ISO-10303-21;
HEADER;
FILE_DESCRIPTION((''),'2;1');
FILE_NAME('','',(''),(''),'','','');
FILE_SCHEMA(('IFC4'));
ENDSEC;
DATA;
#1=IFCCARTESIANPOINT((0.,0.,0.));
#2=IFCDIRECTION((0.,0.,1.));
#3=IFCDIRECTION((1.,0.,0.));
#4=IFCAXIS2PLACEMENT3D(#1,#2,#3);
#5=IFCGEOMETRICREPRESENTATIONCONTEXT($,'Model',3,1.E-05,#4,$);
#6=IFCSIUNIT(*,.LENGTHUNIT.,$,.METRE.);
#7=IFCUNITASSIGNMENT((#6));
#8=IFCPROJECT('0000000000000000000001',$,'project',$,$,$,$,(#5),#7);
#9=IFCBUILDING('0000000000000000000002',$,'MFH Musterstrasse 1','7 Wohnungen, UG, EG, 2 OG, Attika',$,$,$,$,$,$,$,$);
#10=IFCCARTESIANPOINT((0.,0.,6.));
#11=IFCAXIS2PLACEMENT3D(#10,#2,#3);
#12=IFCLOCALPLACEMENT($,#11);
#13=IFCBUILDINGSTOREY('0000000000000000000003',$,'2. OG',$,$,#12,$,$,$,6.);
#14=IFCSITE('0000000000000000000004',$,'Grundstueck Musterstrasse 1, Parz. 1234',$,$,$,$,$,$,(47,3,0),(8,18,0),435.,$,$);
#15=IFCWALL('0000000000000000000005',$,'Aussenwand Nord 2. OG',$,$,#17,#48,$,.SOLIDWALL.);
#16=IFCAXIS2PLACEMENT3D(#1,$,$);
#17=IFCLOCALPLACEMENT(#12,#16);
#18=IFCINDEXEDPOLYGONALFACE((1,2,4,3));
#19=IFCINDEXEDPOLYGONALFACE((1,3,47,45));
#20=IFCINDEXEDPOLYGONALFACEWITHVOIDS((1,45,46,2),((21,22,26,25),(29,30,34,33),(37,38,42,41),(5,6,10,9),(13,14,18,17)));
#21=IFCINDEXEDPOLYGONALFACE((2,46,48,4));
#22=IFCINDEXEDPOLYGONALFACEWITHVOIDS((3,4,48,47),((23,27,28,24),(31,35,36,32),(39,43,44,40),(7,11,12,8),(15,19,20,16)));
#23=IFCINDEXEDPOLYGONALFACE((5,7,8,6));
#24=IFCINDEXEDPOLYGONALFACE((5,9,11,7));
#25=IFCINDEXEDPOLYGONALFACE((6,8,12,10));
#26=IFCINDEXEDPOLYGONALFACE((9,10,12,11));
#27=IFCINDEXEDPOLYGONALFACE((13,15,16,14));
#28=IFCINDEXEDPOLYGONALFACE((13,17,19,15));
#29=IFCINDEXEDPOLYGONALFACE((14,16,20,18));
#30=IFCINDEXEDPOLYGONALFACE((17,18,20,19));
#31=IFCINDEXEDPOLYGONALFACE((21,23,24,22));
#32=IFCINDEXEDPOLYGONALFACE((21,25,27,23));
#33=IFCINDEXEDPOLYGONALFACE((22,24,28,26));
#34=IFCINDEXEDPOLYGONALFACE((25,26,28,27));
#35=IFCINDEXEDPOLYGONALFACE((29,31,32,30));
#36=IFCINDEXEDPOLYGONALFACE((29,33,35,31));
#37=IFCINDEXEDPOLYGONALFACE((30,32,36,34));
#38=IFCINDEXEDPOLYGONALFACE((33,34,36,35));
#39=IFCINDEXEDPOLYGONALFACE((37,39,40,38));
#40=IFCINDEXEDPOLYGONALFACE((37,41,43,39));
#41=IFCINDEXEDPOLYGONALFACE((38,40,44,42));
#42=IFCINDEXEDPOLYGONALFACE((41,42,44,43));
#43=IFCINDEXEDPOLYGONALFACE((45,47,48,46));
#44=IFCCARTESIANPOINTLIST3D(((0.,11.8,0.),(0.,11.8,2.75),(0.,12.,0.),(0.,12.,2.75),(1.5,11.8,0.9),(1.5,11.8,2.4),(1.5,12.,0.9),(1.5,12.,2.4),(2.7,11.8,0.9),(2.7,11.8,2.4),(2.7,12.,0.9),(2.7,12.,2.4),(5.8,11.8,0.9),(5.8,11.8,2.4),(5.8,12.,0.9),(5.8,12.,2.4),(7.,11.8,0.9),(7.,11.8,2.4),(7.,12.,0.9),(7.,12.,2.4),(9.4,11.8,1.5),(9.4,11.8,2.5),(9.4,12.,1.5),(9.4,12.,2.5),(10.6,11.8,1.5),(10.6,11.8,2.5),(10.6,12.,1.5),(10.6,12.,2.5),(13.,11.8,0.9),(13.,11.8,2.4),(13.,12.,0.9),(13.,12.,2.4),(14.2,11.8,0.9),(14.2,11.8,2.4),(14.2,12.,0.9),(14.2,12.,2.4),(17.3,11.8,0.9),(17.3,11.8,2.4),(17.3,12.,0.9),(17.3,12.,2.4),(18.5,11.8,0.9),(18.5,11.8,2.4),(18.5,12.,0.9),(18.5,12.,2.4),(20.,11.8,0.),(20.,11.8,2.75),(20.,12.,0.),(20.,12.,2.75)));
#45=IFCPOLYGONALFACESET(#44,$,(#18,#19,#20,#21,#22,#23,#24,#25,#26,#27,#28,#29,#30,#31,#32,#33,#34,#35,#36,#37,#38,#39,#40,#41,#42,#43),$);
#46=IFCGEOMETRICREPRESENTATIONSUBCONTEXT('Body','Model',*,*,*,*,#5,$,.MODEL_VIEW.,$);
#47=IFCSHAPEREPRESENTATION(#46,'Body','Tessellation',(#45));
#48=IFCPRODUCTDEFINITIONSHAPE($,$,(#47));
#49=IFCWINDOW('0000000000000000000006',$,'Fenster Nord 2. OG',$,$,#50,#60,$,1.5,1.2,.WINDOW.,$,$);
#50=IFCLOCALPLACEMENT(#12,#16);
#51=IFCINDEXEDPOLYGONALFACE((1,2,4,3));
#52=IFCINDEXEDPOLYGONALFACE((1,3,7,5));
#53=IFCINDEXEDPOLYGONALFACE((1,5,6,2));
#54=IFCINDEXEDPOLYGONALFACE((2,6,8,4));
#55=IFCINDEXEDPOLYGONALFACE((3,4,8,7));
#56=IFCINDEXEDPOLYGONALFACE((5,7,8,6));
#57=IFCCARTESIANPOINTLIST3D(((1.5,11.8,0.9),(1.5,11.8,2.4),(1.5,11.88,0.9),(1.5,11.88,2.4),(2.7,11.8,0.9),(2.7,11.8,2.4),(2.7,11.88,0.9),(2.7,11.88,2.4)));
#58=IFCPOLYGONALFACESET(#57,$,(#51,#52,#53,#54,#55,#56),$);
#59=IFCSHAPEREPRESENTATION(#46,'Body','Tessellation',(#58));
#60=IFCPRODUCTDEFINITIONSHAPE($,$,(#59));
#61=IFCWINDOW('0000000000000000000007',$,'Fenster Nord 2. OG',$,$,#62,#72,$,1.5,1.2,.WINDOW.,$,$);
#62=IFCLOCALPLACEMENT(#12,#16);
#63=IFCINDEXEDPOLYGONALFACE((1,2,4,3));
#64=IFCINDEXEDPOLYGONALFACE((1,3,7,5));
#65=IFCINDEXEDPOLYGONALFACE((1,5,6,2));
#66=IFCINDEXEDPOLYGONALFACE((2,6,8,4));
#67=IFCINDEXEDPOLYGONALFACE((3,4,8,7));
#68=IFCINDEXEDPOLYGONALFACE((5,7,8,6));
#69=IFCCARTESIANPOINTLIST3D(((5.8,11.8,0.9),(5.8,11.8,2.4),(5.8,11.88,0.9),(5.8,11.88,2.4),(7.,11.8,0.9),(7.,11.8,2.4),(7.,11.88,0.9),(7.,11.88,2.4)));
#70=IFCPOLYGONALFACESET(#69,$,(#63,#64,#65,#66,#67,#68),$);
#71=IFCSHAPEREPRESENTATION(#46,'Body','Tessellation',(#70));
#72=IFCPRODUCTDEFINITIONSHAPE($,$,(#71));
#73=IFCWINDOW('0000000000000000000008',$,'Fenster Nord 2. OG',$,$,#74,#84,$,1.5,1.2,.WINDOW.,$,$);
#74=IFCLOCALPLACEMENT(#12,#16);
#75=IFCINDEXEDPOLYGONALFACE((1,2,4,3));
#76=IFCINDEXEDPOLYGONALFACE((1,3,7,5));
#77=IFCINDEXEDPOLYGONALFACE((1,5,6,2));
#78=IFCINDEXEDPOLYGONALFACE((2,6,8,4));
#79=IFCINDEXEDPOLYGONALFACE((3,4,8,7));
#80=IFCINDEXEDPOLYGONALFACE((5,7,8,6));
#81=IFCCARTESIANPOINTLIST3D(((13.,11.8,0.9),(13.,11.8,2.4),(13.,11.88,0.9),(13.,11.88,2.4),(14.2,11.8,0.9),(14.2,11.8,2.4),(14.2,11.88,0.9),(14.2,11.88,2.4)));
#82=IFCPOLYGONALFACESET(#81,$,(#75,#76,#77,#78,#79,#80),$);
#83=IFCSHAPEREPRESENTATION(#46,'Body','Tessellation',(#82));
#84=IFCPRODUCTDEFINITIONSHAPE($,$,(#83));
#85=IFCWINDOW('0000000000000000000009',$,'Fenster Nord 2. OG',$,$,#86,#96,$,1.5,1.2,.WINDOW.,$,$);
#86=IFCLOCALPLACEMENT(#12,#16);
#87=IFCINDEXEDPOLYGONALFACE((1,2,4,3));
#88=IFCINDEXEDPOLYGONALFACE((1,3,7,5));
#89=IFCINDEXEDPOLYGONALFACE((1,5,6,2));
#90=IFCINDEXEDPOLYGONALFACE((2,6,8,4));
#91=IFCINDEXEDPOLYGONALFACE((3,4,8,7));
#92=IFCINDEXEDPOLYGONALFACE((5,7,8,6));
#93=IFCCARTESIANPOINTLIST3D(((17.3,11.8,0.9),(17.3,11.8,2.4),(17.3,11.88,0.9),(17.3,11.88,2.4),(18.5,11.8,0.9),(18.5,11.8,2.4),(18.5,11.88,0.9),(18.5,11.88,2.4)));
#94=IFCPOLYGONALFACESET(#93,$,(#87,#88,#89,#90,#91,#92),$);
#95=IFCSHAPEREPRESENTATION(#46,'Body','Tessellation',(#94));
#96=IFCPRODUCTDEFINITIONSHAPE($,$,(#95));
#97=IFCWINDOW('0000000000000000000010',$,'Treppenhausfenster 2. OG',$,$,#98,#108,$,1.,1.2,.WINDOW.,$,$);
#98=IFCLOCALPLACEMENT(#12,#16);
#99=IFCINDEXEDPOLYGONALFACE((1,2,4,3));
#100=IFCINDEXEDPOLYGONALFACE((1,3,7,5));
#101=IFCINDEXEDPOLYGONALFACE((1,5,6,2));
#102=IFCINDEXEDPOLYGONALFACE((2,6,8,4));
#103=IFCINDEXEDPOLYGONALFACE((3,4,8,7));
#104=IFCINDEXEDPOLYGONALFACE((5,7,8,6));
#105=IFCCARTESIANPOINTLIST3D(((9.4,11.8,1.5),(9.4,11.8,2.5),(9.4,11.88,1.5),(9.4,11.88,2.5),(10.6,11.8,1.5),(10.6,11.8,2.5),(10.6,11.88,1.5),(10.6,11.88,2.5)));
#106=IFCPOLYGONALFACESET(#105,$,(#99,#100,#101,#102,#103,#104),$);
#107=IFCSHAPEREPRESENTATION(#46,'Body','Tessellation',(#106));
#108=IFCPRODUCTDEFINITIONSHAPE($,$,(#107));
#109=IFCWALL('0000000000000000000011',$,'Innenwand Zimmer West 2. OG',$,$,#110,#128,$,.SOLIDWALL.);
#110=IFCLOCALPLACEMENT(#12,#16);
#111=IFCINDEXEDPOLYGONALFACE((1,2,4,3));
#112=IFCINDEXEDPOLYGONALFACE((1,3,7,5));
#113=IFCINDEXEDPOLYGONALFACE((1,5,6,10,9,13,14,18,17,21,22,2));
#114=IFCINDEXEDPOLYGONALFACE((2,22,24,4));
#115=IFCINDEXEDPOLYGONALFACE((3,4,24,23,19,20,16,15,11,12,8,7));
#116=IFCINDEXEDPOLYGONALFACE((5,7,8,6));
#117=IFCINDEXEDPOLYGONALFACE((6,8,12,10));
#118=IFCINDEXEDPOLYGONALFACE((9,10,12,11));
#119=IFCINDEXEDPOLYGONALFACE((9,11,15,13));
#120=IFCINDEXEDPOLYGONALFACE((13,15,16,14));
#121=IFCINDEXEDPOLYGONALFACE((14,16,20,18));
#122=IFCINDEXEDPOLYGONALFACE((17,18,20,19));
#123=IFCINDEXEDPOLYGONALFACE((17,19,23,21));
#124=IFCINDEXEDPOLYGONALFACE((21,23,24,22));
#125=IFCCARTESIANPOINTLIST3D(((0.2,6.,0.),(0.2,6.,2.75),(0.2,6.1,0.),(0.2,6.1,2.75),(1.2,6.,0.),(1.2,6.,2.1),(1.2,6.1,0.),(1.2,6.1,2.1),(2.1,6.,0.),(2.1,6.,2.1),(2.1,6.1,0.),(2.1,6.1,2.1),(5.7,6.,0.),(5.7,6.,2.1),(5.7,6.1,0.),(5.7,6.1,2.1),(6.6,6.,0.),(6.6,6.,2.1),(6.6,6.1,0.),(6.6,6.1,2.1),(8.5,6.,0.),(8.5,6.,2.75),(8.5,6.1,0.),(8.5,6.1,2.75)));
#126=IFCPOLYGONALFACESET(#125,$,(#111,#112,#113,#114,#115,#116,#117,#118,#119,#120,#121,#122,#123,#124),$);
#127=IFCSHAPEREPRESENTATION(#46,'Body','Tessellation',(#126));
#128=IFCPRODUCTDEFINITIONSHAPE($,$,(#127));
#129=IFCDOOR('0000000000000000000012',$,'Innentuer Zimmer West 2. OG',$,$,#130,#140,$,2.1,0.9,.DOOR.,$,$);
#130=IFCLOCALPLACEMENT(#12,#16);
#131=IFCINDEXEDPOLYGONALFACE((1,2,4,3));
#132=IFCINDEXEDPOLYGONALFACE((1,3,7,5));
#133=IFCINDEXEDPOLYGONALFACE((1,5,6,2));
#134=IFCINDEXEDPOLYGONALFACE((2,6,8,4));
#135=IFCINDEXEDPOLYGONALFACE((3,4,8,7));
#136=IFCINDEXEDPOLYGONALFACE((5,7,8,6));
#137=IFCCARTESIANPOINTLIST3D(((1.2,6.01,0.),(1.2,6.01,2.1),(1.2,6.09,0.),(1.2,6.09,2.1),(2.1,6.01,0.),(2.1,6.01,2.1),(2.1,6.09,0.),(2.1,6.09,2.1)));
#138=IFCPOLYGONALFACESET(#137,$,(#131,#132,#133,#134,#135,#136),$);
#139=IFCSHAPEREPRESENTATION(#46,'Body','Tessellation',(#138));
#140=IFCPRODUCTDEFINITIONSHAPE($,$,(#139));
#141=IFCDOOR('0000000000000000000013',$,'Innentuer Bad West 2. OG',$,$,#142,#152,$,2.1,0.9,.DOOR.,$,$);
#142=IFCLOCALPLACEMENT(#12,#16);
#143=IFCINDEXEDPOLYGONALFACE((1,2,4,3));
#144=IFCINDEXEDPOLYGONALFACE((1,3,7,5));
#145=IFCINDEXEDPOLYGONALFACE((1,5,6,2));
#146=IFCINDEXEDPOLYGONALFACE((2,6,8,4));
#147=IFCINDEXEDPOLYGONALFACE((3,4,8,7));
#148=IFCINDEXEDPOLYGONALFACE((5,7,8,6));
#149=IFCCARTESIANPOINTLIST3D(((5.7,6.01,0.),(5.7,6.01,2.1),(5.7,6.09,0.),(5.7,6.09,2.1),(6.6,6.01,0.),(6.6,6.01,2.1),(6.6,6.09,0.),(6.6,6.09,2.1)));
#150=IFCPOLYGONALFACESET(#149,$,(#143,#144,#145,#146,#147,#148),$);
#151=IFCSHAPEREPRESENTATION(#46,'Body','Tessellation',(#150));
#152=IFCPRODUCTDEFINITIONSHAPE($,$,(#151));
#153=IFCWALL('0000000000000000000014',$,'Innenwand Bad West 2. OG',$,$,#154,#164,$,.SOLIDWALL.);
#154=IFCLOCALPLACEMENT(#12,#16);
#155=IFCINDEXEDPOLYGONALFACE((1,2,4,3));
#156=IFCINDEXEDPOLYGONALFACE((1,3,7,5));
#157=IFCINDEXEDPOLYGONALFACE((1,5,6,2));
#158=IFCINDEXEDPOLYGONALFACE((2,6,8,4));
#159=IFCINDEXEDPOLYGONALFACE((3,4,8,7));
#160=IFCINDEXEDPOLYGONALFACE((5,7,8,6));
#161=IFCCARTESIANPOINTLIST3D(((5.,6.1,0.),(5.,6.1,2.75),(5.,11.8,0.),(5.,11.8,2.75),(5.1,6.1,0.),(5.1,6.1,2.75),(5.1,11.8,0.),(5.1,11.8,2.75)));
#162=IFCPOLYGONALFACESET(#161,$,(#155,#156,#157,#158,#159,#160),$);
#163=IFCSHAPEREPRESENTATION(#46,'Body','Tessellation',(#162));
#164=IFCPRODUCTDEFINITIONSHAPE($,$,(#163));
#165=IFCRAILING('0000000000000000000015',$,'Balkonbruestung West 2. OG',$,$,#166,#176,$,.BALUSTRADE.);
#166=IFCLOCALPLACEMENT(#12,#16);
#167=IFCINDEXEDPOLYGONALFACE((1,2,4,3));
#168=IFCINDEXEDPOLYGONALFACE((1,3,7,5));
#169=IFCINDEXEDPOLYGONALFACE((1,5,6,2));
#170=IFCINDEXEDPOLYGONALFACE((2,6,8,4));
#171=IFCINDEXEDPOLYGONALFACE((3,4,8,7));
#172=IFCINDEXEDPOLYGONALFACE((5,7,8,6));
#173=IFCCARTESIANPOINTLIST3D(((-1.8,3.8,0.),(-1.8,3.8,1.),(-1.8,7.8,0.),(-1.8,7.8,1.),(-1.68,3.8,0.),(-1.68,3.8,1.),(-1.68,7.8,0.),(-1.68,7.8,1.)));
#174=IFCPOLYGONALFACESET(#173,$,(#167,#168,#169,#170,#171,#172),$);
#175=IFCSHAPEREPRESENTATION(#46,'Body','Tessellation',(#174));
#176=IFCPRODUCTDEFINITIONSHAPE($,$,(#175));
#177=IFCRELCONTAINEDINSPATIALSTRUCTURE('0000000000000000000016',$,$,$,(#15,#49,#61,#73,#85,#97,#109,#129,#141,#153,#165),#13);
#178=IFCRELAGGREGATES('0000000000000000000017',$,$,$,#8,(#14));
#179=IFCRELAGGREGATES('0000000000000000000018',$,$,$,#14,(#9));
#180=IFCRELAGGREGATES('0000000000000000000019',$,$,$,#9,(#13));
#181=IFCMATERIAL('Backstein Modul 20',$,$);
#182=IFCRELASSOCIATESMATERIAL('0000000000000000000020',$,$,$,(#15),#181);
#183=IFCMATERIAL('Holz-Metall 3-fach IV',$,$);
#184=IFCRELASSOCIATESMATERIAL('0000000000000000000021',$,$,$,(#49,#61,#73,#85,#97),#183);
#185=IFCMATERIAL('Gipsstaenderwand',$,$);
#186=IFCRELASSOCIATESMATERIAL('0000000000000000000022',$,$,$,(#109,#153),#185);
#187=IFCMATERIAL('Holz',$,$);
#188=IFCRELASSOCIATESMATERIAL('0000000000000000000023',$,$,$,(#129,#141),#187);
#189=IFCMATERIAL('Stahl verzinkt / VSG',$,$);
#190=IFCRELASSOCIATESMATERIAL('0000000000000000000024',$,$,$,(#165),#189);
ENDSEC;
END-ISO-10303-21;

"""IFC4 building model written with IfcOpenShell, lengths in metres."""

from ifc_helpers import new_model, si_unit, frame, frame_2d, origin_with_axes, place, context, subcontext, project, spatial, rectangle, extrude, material, element, fill, save


model = new_model("IFC4")

# Units and contexts
model_context = context("Model", 3, precision=1e-05, world=origin_with_axes())
body_context = subcontext(model_context, "Body", "Model", "MODEL_VIEW")
ifc_project = project(units=[si_unit("LENGTHUNIT", "METRE")], contexts=[model_context])

# Site, building, storey
site = spatial("IfcSite", under=ifc_project, Name="Grundstueck Musterstrasse 1, Parz. 1234", RefLatitude=(47, 3, 0), RefLongitude=(8, 18, 0), RefElevation=435.0)
building = spatial("IfcBuilding", under=site, Name="MFH Musterstrasse 1", Description="7 Wohnungen, UG, EG, 2 OG, Attika")
storey_placement = place(None, frame((0.0, 0.0, 6.0), z_axis=(0.0, 0.0, 1.0), x_axis=(1.0, 0.0, 0.0)))
storey = spatial("IfcBuildingStorey", under=building, at=storey_placement, Name="2. OG", Elevation=6.0)

# Wall, openings, windows
ifc_material_1 = material(Name="Backstein Modul 20")
wall_1_placement = place(storey_placement, frame((0.0, 11.8, 0.0), z_axis=(0.0, 0.0, 1.0), x_axis=(1.0, 0.0, 0.0)))
wall_1 = element("IfcWall", 1, at=wall_1_placement, inside=storey, material=ifc_material_1, Name="Aussenwand Nord 2. OG", PredefinedType="SOLIDWALL", context=body_context, shape_type="SweptSolid", body=[
    extrude(rectangle(XDim=20.0, YDim=0.2, at=frame_2d((10.0, 0.1))), origin_with_axes(), (0.0, 0.0, 1.0), 2.75),
])
opening_1_placement = place(wall_1_placement, frame((1.5, -0.01, 0.9), z_axis=(0.0, 0.0, 1.0), x_axis=(1.0, 0.0, 0.0)))
opening_1 = element("IfcOpeningElement", 2, at=opening_1_placement, cuts=wall_1, context=body_context, shape_type="SweptSolid", body=[
    extrude(rectangle(XDim=1.2, YDim=0.42, at=frame_2d((0.6, 0.21))), origin_with_axes(), (0.0, 0.0, 1.0), 1.5),
])
opening_2_placement = place(wall_1_placement, frame((5.8, -0.01, 0.9), z_axis=(0.0, 0.0, 1.0), x_axis=(1.0, 0.0, 0.0)))
opening_2 = element("IfcOpeningElement", 3, at=opening_2_placement, cuts=wall_1, context=body_context, shape_type="SweptSolid", body=[
    extrude(rectangle(XDim=1.2, YDim=0.42, at=frame_2d((0.6, 0.21))), origin_with_axes(), (0.0, 0.0, 1.0), 1.5),
])
opening_3_placement = place(wall_1_placement, frame((13.0, -0.01, 0.9), z_axis=(0.0, 0.0, 1.0), x_axis=(1.0, 0.0, 0.0)))
opening_3 = element("IfcOpeningElement", 4, at=opening_3_placement, cuts=wall_1, context=body_context, shape_type="SweptSolid", body=[
    extrude(rectangle(XDim=1.2, YDim=0.42, at=frame_2d((0.6, 0.21))), origin_with_axes(), (0.0, 0.0, 1.0), 1.5),
])
opening_4_placement = place(wall_1_placement, frame((17.3, -0.01, 0.9), z_axis=(0.0, 0.0, 1.0), x_axis=(1.0, 0.0, 0.0)))
opening_4 = element("IfcOpeningElement", 5, at=opening_4_placement, cuts=wall_1, context=body_context, shape_type="SweptSolid", body=[
    extrude(rectangle(XDim=1.2, YDim=0.42, at=frame_2d((0.6, 0.21))), origin_with_axes(), (0.0, 0.0, 1.0), 1.5),
])
opening_5_placement = place(wall_1_placement, frame((9.4, -0.01, 1.5), z_axis=(0.0, 0.0, 1.0), x_axis=(1.0, 0.0, 0.0)))
opening_5 = element("IfcOpeningElement", 6, at=opening_5_placement, cuts=wall_1, context=body_context, shape_type="SweptSolid", body=[
    extrude(rectangle(XDim=1.2, YDim=0.42, at=frame_2d((0.6, 0.21))), origin_with_axes(), (0.0, 0.0, 1.0), 1.0),
])
ifc_material_2 = material(Name="Holz-Metall 3-fach IV")
window_1_placement = place(storey_placement, frame((1.5, 11.8, 0.9), z_axis=(0.0, 0.0, 1.0), x_axis=(1.0, 0.0, 0.0)))
window_1 = element("IfcWindow", 7, at=window_1_placement, inside=storey, material=ifc_material_2, Name="Fenster Nord 2. OG", OverallHeight=1.5, OverallWidth=1.2, PredefinedType="WINDOW", context=body_context, shape_type="SweptSolid", body=[
    extrude(rectangle(XDim=1.2, YDim=0.08, at=frame_2d((0.6, 0.04))), origin_with_axes(), (0.0, 0.0, 1.0), 1.5),
])
fill(opening_1, window_1)
window_2_placement = place(storey_placement, frame((5.8, 11.8, 0.9), z_axis=(0.0, 0.0, 1.0), x_axis=(1.0, 0.0, 0.0)))
window_2 = element("IfcWindow", 8, at=window_2_placement, inside=storey, material=ifc_material_2, Name="Fenster Nord 2. OG", OverallHeight=1.5, OverallWidth=1.2, PredefinedType="WINDOW", context=body_context, shape_type="SweptSolid", body=[
    extrude(rectangle(XDim=1.2, YDim=0.08, at=frame_2d((0.6, 0.04))), origin_with_axes(), (0.0, 0.0, 1.0), 1.5),
])
fill(opening_2, window_2)
window_3_placement = place(storey_placement, frame((13.0, 11.8, 0.9), z_axis=(0.0, 0.0, 1.0), x_axis=(1.0, 0.0, 0.0)))
window_3 = element("IfcWindow", 9, at=window_3_placement, inside=storey, material=ifc_material_2, Name="Fenster Nord 2. OG", OverallHeight=1.5, OverallWidth=1.2, PredefinedType="WINDOW", context=body_context, shape_type="SweptSolid", body=[
    extrude(rectangle(XDim=1.2, YDim=0.08, at=frame_2d((0.6, 0.04))), origin_with_axes(), (0.0, 0.0, 1.0), 1.5),
])
fill(opening_3, window_3)
window_4_placement = place(storey_placement, frame((17.3, 11.8, 0.9), z_axis=(0.0, 0.0, 1.0), x_axis=(1.0, 0.0, 0.0)))
window_4 = element("IfcWindow", 10, at=window_4_placement, inside=storey, material=ifc_material_2, Name="Fenster Nord 2. OG", OverallHeight=1.5, OverallWidth=1.2, PredefinedType="WINDOW", context=body_context, shape_type="SweptSolid", body=[
    extrude(rectangle(XDim=1.2, YDim=0.08, at=frame_2d((0.6, 0.04))), origin_with_axes(), (0.0, 0.0, 1.0), 1.5),
])
fill(opening_4, window_4)
window_5_placement = place(storey_placement, frame((9.4, 11.8, 1.5), z_axis=(0.0, 0.0, 1.0), x_axis=(1.0, 0.0, 0.0)))
window_5 = element("IfcWindow", 11, at=window_5_placement, inside=storey, material=ifc_material_2, Name="Treppenhausfenster 2. OG", OverallHeight=1.0, OverallWidth=1.2, PredefinedType="WINDOW", context=body_context, shape_type="SweptSolid", body=[
    extrude(rectangle(XDim=1.2, YDim=0.08, at=frame_2d((0.6, 0.04))), origin_with_axes(), (0.0, 0.0, 1.0), 1.0),
])
fill(opening_5, window_5)

# Wall, openings, doors
ifc_material_3 = material(Name="Gipsstaenderwand")
wall_2_placement = place(storey_placement, frame((0.2, 6.0, 0.0), z_axis=(0.0, 0.0, 1.0), x_axis=(1.0, 0.0, 0.0)))
wall_2 = element("IfcWall", 12, at=wall_2_placement, inside=storey, material=ifc_material_3, Name="Innenwand Zimmer West 2. OG", PredefinedType="SOLIDWALL", context=body_context, shape_type="SweptSolid", body=[
    extrude(rectangle(XDim=8.3, YDim=0.1, at=frame_2d((4.15, 0.05))), origin_with_axes(), (0.0, 0.0, 1.0), 2.75),
])
opening_6_placement = place(wall_2_placement, frame((1.0, -0.01, 0.0), z_axis=(0.0, 0.0, 1.0), x_axis=(1.0, 0.0, 0.0)))
opening_6 = element("IfcOpeningElement", 13, at=opening_6_placement, cuts=wall_2, context=body_context, shape_type="SweptSolid", body=[
    extrude(rectangle(XDim=0.9, YDim=0.12, at=frame_2d((0.45, 0.06))), origin_with_axes(), (0.0, 0.0, 1.0), 2.1),
])
opening_7_placement = place(wall_2_placement, frame((5.5, -0.01, 0.0), z_axis=(0.0, 0.0, 1.0), x_axis=(1.0, 0.0, 0.0)))
opening_7 = element("IfcOpeningElement", 14, at=opening_7_placement, cuts=wall_2, context=body_context, shape_type="SweptSolid", body=[
    extrude(rectangle(XDim=0.9, YDim=0.12, at=frame_2d((0.45, 0.06))), origin_with_axes(), (0.0, 0.0, 1.0), 2.1),
])
ifc_material_4 = material(Name="Holz")
door_1_placement = place(storey_placement, frame((1.2, 6.01, 0.0), z_axis=(0.0, 0.0, 1.0), x_axis=(1.0, 0.0, 0.0)))
door_1 = element("IfcDoor", 15, at=door_1_placement, inside=storey, material=ifc_material_4, Name="Innentuer Zimmer West 2. OG", OverallHeight=2.1, OverallWidth=0.9, PredefinedType="DOOR", context=body_context, shape_type="SweptSolid", body=[
    extrude(rectangle(XDim=0.9, YDim=0.08, at=frame_2d((0.45, 0.04))), origin_with_axes(), (0.0, 0.0, 1.0), 2.1),
])
fill(opening_6, door_1)
door_2_placement = place(storey_placement, frame((5.7, 6.01, 0.0), z_axis=(0.0, 0.0, 1.0), x_axis=(1.0, 0.0, 0.0)))
door_2 = element("IfcDoor", 16, at=door_2_placement, inside=storey, material=ifc_material_4, Name="Innentuer Bad West 2. OG", OverallHeight=2.1, OverallWidth=0.9, PredefinedType="DOOR", context=body_context, shape_type="SweptSolid", body=[
    extrude(rectangle(XDim=0.9, YDim=0.08, at=frame_2d((0.45, 0.04))), origin_with_axes(), (0.0, 0.0, 1.0), 2.1),
])
fill(opening_7, door_2)

# Wall
wall_3_placement = place(storey_placement, frame((5.0, 6.1, 0.0), z_axis=(0.0, 0.0, 1.0), x_axis=(1.0, 0.0, 0.0)))
element("IfcWall", 17, at=wall_3_placement, inside=storey, material=ifc_material_3, Name="Innenwand Bad West 2. OG", PredefinedType="SOLIDWALL", context=body_context, shape_type="SweptSolid", body=[
    extrude(rectangle(XDim=0.1, YDim=5.7, at=frame_2d((0.05, 2.85))), origin_with_axes(), (0.0, 0.0, 1.0), 2.75),
])

# Railing
ifc_material_5 = material(Name="Stahl verzinkt / VSG")
railing_placement = place(storey_placement, frame((-1.8, 3.8, 0.0), z_axis=(0.0, 0.0, 1.0), x_axis=(1.0, 0.0, 0.0)))
element("IfcRailing", 18, at=railing_placement, inside=storey, material=ifc_material_5, Name="Balkonbruestung West 2. OG", PredefinedType="BALUSTRADE", context=body_context, shape_type="SweptSolid", body=[
    extrude(rectangle(XDim=0.12, YDim=4.0, at=frame_2d((0.06, 2.0))), origin_with_axes(), (0.0, 0.0, 1.0), 1.0),
])

save(model, "model.ifc")
